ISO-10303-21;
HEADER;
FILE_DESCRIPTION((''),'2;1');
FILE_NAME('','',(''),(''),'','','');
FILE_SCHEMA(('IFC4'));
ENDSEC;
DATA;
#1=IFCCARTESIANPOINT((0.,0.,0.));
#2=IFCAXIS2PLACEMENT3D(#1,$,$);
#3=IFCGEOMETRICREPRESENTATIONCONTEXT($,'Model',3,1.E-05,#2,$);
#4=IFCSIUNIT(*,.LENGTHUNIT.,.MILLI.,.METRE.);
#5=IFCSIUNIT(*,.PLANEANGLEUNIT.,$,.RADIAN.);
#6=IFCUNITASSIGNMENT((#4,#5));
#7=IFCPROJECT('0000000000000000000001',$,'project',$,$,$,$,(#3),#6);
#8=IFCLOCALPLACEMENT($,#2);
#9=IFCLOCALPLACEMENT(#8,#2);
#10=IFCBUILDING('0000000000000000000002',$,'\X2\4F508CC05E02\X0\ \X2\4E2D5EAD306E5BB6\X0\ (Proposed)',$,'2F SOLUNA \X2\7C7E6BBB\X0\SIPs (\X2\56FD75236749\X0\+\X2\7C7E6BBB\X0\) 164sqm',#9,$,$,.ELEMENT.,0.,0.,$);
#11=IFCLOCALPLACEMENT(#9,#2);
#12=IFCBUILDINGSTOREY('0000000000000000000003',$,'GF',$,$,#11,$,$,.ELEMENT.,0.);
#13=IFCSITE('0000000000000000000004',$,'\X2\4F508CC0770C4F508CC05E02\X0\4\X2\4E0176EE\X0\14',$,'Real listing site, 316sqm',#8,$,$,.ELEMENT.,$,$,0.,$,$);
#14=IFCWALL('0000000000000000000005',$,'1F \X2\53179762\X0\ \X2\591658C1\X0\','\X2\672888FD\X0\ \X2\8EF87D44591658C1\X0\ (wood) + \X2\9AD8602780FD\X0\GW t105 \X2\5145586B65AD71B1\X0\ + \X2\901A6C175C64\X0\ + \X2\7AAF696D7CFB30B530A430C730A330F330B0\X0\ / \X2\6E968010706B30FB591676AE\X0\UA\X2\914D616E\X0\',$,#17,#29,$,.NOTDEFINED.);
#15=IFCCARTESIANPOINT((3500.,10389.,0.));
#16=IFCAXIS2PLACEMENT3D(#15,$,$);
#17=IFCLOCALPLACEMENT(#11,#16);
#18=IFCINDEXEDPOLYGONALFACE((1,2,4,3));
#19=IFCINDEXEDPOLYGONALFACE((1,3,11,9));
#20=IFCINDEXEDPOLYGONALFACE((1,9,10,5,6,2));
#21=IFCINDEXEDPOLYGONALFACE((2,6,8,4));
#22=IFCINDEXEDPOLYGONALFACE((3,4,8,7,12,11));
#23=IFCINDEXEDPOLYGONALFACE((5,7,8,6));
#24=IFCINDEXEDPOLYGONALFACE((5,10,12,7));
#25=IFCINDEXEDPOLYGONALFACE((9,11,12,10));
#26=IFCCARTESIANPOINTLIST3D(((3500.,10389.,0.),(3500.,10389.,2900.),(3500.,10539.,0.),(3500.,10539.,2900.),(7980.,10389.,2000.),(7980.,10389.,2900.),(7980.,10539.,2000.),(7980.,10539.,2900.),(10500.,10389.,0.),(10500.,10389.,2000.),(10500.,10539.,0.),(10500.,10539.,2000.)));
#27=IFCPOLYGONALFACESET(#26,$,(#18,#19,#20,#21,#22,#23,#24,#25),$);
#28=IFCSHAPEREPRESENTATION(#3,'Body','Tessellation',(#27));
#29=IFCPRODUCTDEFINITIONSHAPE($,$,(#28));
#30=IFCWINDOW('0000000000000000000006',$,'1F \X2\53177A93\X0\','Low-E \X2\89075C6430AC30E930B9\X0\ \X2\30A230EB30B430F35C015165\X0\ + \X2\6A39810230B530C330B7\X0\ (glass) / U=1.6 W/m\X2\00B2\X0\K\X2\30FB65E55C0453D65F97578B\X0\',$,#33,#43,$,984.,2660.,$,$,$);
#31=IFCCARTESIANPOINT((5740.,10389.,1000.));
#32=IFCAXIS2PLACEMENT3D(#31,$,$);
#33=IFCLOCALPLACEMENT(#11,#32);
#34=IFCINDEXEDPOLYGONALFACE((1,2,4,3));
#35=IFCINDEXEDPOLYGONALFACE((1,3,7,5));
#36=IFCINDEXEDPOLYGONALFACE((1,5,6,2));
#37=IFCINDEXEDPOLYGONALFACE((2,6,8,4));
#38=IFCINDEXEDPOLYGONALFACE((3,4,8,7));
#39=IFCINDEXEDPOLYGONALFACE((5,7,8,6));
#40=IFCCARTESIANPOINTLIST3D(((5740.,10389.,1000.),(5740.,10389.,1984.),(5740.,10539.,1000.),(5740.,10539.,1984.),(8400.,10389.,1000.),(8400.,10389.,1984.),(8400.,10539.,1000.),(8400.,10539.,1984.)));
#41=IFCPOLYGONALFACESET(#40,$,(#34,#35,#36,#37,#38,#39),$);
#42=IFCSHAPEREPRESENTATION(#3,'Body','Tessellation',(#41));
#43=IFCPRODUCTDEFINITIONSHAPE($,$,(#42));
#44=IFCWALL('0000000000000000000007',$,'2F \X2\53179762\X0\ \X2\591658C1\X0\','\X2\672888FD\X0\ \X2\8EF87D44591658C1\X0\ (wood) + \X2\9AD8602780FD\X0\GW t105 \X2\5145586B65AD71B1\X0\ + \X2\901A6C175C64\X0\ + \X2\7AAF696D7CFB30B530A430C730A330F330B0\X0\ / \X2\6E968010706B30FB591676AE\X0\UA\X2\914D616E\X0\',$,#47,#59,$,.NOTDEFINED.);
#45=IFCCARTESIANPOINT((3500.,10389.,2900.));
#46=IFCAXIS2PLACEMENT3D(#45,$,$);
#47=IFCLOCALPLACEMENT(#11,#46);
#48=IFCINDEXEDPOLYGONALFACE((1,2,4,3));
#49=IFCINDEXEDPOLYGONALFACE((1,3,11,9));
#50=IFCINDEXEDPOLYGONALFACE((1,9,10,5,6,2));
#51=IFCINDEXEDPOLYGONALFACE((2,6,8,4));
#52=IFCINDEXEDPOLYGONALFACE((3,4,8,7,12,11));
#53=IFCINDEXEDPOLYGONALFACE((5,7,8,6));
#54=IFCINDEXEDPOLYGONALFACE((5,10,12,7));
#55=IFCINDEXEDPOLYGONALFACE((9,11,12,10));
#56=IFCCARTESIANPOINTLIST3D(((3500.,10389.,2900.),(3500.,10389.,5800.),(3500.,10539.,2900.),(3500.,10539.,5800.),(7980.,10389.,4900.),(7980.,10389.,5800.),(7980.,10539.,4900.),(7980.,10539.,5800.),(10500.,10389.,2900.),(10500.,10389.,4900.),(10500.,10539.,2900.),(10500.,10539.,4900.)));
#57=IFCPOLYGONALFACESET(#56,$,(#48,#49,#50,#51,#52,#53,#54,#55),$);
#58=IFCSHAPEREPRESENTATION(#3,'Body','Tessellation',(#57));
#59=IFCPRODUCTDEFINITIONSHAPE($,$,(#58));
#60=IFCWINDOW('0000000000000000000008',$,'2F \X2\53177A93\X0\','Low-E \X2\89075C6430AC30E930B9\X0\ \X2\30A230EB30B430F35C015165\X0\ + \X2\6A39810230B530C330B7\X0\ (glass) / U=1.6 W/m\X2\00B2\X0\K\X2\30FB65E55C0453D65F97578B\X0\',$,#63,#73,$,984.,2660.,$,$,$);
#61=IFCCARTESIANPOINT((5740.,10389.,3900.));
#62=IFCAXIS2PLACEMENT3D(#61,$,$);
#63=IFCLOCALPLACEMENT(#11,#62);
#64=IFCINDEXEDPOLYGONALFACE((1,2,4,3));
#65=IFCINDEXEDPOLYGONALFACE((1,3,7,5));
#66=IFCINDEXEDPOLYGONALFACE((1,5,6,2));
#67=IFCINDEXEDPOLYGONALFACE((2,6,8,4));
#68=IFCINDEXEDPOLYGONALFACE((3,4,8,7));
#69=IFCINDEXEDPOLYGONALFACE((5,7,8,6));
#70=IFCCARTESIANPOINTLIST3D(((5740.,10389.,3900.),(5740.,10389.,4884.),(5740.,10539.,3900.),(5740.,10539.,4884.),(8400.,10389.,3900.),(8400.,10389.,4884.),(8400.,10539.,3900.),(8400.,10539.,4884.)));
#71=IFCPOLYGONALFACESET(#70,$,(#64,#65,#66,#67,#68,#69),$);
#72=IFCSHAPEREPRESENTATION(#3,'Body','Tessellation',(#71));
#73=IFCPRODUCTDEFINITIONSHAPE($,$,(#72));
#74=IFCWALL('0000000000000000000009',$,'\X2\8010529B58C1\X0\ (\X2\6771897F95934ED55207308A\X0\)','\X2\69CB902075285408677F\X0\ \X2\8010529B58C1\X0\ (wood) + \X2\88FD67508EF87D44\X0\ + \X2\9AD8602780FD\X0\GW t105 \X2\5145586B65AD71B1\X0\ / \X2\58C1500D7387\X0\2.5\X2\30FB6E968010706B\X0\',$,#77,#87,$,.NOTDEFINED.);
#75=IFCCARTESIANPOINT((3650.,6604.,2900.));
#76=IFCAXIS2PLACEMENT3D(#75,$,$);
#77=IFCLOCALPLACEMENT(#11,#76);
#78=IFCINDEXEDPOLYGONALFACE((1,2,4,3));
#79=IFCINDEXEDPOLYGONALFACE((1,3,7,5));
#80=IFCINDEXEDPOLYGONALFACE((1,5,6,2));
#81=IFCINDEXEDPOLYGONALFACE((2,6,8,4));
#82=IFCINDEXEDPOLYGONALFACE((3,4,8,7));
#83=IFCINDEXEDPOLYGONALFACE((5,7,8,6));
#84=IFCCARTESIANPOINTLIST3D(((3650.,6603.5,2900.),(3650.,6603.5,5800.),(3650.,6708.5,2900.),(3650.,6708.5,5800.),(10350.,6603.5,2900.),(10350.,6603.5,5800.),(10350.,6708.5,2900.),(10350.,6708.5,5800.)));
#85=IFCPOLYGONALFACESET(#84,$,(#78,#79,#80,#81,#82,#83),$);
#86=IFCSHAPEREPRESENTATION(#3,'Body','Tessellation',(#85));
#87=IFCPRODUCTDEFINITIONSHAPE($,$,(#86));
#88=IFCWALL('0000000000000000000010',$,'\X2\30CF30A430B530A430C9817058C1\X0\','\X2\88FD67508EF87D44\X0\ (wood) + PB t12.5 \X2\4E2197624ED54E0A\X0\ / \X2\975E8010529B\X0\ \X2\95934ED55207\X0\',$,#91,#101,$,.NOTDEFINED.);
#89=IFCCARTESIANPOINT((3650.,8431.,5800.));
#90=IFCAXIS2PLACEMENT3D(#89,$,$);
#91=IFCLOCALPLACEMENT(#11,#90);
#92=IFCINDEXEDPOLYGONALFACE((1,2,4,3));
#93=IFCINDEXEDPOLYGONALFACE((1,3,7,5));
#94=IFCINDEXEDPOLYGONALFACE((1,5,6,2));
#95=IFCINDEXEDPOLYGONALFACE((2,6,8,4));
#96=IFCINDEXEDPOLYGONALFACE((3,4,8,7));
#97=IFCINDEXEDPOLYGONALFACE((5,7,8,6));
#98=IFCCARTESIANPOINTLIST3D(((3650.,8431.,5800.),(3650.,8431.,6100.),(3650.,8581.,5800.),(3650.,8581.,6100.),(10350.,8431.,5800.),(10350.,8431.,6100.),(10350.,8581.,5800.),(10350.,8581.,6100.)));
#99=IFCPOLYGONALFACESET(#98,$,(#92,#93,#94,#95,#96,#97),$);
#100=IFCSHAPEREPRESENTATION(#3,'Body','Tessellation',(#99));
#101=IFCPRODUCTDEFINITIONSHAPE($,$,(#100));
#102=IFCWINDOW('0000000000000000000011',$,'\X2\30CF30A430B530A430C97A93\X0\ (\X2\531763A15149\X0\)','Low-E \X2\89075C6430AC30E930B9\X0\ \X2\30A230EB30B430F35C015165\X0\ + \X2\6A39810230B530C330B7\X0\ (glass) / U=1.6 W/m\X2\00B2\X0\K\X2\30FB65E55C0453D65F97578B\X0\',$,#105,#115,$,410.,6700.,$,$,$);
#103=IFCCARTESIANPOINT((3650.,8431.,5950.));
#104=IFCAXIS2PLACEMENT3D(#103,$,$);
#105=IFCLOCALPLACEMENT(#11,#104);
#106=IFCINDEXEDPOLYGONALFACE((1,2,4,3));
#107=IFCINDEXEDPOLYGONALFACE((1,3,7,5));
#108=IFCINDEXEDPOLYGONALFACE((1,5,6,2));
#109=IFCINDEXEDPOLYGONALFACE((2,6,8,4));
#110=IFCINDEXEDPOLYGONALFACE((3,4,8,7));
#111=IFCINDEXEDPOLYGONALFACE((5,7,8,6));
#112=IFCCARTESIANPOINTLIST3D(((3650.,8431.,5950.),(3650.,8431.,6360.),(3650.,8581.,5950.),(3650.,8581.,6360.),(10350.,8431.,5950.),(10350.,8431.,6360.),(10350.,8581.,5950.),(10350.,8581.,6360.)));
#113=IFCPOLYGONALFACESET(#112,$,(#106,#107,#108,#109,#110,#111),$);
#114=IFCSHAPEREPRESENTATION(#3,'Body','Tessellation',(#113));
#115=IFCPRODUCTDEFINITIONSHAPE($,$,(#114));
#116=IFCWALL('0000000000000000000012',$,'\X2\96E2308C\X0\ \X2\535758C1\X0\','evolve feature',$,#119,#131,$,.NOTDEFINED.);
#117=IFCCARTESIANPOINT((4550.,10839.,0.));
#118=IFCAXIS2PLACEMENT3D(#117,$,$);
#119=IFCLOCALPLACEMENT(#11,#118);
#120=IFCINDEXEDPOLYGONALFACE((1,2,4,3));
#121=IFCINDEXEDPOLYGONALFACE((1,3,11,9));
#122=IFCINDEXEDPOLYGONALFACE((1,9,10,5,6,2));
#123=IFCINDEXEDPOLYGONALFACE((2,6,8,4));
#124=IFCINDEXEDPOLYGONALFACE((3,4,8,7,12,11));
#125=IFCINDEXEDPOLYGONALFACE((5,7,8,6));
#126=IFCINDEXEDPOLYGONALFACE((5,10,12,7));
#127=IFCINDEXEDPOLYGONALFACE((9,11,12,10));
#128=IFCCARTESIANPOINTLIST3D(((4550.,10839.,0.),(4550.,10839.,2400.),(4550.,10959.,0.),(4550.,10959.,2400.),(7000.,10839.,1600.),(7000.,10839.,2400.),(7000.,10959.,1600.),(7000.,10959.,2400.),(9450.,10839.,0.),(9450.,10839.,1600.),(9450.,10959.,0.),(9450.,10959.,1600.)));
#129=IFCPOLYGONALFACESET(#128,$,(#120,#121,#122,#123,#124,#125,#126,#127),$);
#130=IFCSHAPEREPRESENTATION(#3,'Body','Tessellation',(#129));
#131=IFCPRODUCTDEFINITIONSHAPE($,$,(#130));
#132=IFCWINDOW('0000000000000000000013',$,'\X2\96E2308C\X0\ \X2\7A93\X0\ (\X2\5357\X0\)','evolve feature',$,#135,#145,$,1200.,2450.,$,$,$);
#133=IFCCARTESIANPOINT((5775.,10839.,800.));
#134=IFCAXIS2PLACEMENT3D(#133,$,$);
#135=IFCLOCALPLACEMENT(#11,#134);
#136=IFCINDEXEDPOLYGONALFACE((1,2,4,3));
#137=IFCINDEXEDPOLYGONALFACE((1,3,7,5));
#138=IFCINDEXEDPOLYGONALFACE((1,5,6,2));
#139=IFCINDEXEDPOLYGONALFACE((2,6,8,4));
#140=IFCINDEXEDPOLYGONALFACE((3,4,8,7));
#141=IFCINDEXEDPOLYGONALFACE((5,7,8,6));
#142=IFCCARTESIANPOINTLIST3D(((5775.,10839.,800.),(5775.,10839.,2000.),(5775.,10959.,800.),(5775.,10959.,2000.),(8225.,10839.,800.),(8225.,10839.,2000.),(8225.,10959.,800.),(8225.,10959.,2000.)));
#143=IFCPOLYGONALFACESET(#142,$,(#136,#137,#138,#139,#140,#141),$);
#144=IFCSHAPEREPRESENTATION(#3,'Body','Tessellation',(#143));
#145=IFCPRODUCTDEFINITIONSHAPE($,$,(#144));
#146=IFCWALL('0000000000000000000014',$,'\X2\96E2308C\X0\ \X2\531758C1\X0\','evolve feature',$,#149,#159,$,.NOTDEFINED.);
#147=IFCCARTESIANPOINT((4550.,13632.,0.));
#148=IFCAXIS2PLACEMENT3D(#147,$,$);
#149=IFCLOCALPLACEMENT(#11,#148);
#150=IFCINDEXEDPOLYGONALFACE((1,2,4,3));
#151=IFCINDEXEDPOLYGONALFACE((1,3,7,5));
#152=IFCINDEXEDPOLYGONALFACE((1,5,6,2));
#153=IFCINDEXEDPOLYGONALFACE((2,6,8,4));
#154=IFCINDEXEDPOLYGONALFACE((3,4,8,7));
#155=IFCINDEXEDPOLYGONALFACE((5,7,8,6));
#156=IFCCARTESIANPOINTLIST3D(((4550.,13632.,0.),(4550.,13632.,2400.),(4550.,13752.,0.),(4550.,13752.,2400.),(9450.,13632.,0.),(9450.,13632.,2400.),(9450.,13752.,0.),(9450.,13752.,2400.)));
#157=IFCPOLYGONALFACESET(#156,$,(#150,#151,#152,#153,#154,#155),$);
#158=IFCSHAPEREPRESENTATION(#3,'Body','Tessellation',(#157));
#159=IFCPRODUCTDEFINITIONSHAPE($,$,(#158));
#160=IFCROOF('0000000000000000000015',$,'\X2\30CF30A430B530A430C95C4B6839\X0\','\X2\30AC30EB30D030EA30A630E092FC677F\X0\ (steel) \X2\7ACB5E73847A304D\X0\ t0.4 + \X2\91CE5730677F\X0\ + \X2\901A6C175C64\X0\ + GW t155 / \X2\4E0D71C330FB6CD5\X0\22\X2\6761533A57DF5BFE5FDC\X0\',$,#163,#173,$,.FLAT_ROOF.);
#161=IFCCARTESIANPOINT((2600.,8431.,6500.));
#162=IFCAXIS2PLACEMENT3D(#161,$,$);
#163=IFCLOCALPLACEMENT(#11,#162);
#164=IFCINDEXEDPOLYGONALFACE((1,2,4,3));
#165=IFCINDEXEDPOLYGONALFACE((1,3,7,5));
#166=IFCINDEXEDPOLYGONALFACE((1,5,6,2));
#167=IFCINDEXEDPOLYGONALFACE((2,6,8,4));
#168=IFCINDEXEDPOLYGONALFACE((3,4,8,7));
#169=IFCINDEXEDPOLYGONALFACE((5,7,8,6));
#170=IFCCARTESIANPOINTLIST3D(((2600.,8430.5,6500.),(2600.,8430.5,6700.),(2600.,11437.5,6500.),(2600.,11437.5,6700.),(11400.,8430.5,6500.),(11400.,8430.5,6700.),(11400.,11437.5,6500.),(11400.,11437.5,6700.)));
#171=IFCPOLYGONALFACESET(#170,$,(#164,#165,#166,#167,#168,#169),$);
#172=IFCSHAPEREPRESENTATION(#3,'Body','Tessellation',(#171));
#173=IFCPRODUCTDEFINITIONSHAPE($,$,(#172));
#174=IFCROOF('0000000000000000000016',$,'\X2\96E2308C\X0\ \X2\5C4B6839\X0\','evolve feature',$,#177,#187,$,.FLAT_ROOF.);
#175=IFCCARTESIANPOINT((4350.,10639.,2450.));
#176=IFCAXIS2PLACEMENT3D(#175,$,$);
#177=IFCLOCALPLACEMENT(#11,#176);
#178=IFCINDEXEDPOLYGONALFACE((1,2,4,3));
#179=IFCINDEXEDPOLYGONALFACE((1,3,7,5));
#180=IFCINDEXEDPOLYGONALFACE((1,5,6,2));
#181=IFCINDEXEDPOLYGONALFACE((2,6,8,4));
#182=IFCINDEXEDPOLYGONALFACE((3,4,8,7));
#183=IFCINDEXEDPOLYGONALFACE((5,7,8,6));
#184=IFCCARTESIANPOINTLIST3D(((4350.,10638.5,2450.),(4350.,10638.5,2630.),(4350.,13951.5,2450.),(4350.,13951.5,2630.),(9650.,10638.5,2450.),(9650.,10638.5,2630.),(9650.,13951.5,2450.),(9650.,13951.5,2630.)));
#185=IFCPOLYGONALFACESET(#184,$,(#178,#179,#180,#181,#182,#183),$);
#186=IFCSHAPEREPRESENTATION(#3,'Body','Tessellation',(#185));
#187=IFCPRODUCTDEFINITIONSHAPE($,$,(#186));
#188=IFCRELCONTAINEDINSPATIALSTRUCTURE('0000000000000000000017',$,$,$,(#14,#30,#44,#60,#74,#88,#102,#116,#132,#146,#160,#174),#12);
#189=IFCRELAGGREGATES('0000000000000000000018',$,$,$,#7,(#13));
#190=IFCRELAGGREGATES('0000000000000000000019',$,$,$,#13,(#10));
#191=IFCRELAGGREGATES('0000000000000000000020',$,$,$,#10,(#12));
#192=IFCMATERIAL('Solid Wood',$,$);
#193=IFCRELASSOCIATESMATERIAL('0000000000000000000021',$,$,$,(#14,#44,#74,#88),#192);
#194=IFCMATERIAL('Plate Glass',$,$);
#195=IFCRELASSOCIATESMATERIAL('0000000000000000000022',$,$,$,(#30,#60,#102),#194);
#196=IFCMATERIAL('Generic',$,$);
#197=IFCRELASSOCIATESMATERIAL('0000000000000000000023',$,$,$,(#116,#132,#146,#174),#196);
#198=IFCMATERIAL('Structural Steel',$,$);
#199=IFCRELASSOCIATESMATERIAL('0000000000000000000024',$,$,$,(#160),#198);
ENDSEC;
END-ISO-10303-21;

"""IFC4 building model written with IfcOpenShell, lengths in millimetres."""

from ifc_helpers import new_model, si_unit, frame, frame_2d, origin, place, context, project, spatial, rectangle, extrude, material, element, fill, save


model = new_model("IFC4")

# Units and contexts
model_context = context("Model", 3, precision=1e-05, world=origin())
ifc_project = project(units=[si_unit("LENGTHUNIT", "METRE", prefix="MILLI"), si_unit("PLANEANGLEUNIT", "RADIAN")], contexts=[model_context])

# Site, building, storey
site_placement = place(None, origin())
site = spatial("IfcSite", under=ifc_project, at=site_placement, Name="佐賀県佐賀市4丁目14", ObjectType="Real listing site, 316sqm", CompositionType="ELEMENT", RefElevation=0.0)
building_placement = place(site_placement, origin())
building = spatial("IfcBuilding", under=site, at=building_placement, Name="佐賀市 中庭の家 (Proposed)", ObjectType="2F SOLUNA 籾殻SIPs (国産杉+籾殻) 164sqm", CompositionType="ELEMENT", ElevationOfRefHeight=0.0, ElevationOfTerrain=0.0)
storey_placement = place(building_placement, origin())
storey = spatial("IfcBuildingStorey", under=building, at=storey_placement, Name="GF", CompositionType="ELEMENT", Elevation=0.0)

# Shared definitions
ifc_material_1 = material(Name="Generic")

# Wall, opening, window
ifc_material_2 = material(Name="Solid Wood")
wall_1_placement = place(storey_placement, frame((3500.0, 10389.0, 0.0)))
wall_1 = element("IfcWall", 1, at=wall_1_placement, inside=storey, material=ifc_material_2, Name="1F 北面 外壁", Description="木製 軸組外壁 (wood) + 高性能GW t105 充填断熱 + 通気層 + 窯業系サイディング / 準耐火・外皮UA配慮", PredefinedType="NOTDEFINED", context=model_context, shape_type="SweptSolid", body=[
    extrude(rectangle(XDim=7000.0, YDim=150.0, at=frame_2d((3500.0, 75.0))), frame((3500.0, 10389.0, 0.0)), (0.0, 0.0, 1.0), 2900.0),
])
opening_1_placement = place(storey_placement, frame((5740.0, 10389.0, 1000.0)))
opening_1 = element("IfcOpeningElement", 2, at=opening_1_placement, cuts=wall_1, PredefinedType="NOTDEFINED", context=model_context, shape_type="SweptSolid", body=[
    extrude(rectangle(XDim=2660.0, YDim=150.0, at=frame_2d((1330.0, 75.0))), frame((5740.0, 10389.0, 1000.0)), (0.0, 0.0, 1.0), 984.0),
])
ifc_material_3 = material(Name="Plate Glass")
window_1_placement = place(storey_placement, frame((5740.0, 10389.0, 1000.0)))
window_1 = element("IfcWindow", 3, at=window_1_placement, inside=storey, material=ifc_material_3, Name="1F 北窓", Description="Low-E 複層ガラス アルゴン封入 + 樹脂サッシ (glass) / U=1.6 W/m²K・日射取得型", OverallHeight=984.0, OverallWidth=2660.0, context=model_context, shape_type="SweptSolid", body=[
    extrude(rectangle(XDim=2660.0, YDim=150.0, at=frame_2d((1330.0, 75.0))), frame((5740.0, 10389.0, 1000.0)), (0.0, 0.0, 1.0), 984.0),
])
fill(opening_1, window_1)

# Wall, opening, window
wall_2_placement = place(storey_placement, frame((3500.0, 10389.0, 2900.0)))
wall_2 = element("IfcWall", 4, at=wall_2_placement, inside=storey, material=ifc_material_2, Name="2F 北面 外壁", Description="木製 軸組外壁 (wood) + 高性能GW t105 充填断熱 + 通気層 + 窯業系サイディング / 準耐火・外皮UA配慮", PredefinedType="NOTDEFINED", context=model_context, shape_type="SweptSolid", body=[
    extrude(rectangle(XDim=7000.0, YDim=150.0, at=frame_2d((3500.0, 75.0))), frame((3500.0, 10389.0, 2900.0)), (0.0, 0.0, 1.0), 2900.0),
])
opening_2_placement = place(storey_placement, frame((5740.0, 10389.0, 3900.0)))
opening_2 = element("IfcOpeningElement", 5, at=opening_2_placement, cuts=wall_2, PredefinedType="NOTDEFINED", context=model_context, shape_type="SweptSolid", body=[
    extrude(rectangle(XDim=2660.0, YDim=150.0, at=frame_2d((1330.0, 75.0))), frame((5740.0, 10389.0, 3900.0)), (0.0, 0.0, 1.0), 984.0),
])
window_2_placement = place(storey_placement, frame((5740.0, 10389.0, 3900.0)))
window_2 = element("IfcWindow", 6, at=window_2_placement, inside=storey, material=ifc_material_3, Name="2F 北窓", Description="Low-E 複層ガラス アルゴン封入 + 樹脂サッシ (glass) / U=1.6 W/m²K・日射取得型", OverallHeight=984.0, OverallWidth=2660.0, context=model_context, shape_type="SweptSolid", body=[
    extrude(rectangle(XDim=2660.0, YDim=150.0, at=frame_2d((1330.0, 75.0))), frame((5740.0, 10389.0, 3900.0)), (0.0, 0.0, 1.0), 984.0),
])
fill(opening_2, window_2)

# Wall
wall_3_placement = place(storey_placement, frame((3650.0, 6604.0, 2900.0)))
element("IfcWall", 7, at=wall_3_placement, inside=storey, material=ifc_material_2, Name="耐力壁 (東西間仕切り)", Description="構造用合板 耐力壁 (wood) + 製材軸組 + 高性能GW t105 充填断熱 / 壁倍率2.5・準耐火", PredefinedType="NOTDEFINED", context=model_context, shape_type="SweptSolid", body=[
    extrude(rectangle(XDim=6700.0, YDim=105.0, at=frame_2d((3350.0, 52.0))), frame((3650.0, 6604.0, 2900.0)), (0.0, 0.0, 1.0), 2900.0),
])

# Walls, openings, windows
wall_4_placement = place(storey_placement, frame((3650.0, 8431.0, 5800.0)))
wall_4 = element("IfcWall", 8, at=wall_4_placement, inside=storey, material=ifc_material_2, Name="ハイサイド腰壁", Description="製材軸組 (wood) + PB t12.5 両面仕上 / 非耐力 間仕切", PredefinedType="NOTDEFINED", context=model_context, shape_type="SweptSolid", body=[
    extrude(rectangle(XDim=6700.0, YDim=150.0, at=frame_2d((3350.0, 75.0))), frame((3650.0, 8431.0, 5800.0)), (0.0, 0.0, 1.0), 700.0),
])
opening_3_placement = place(storey_placement, frame((3650.0, 8431.0, 5950.0)))
opening_3 = element("IfcOpeningElement", 9, at=opening_3_placement, cuts=wall_4, PredefinedType="NOTDEFINED", context=model_context, shape_type="SweptSolid", body=[
    extrude(rectangle(XDim=6700.0, YDim=150.0, at=frame_2d((3350.0, 75.0))), frame((3650.0, 8431.0, 5950.0)), (0.0, 0.0, 1.0), 410.0),
])
window_3_placement = place(storey_placement, frame((3650.0, 8431.0, 5950.0)))
window_3 = element("IfcWindow", 10, at=window_3_placement, inside=storey, material=ifc_material_3, Name="ハイサイド窓 (北採光)", Description="Low-E 複層ガラス アルゴン封入 + 樹脂サッシ (glass) / U=1.6 W/m²K・日射取得型", OverallHeight=410.0, OverallWidth=6700.0, context=model_context, shape_type="SweptSolid", body=[
    extrude(rectangle(XDim=6700.0, YDim=150.0, at=frame_2d((3350.0, 75.0))), frame((3650.0, 8431.0, 5950.0)), (0.0, 0.0, 1.0), 410.0),
])
fill(opening_3, window_3)
wall_5_placement = place(storey_placement, frame((4550.0, 10839.0, 0.0)))
wall_5 = element("IfcWall", 11, at=wall_5_placement, inside=storey, material=ifc_material_1, Name="離れ 南壁", Description="evolve feature", PredefinedType="NOTDEFINED", context=model_context, shape_type="SweptSolid", body=[
    extrude(rectangle(XDim=4900.0, YDim=120.0, at=frame_2d((2450.0, 60.0))), frame((4550.0, 10839.0, 0.0)), (0.0, 0.0, 1.0), 2400.0),
])
opening_4_placement = place(storey_placement, frame((5775.0, 10839.0, 800.0)))
opening_4 = element("IfcOpeningElement", 12, at=opening_4_placement, cuts=wall_5, PredefinedType="NOTDEFINED", context=model_context, shape_type="SweptSolid", body=[
    extrude(rectangle(XDim=2450.0, YDim=120.0, at=frame_2d((1225.0, 60.0))), frame((5775.0, 10839.0, 800.0)), (0.0, 0.0, 1.0), 1200.0),
])
window_4_placement = place(storey_placement, frame((5775.0, 10839.0, 800.0)))
window_4 = element("IfcWindow", 13, at=window_4_placement, inside=storey, material=ifc_material_1, Name="離れ 窓 (南)", Description="evolve feature", OverallHeight=1200.0, OverallWidth=2450.0, context=model_context, shape_type="SweptSolid", body=[
    extrude(rectangle(XDim=2450.0, YDim=120.0, at=frame_2d((1225.0, 60.0))), frame((5775.0, 10839.0, 800.0)), (0.0, 0.0, 1.0), 1200.0),
])
fill(opening_4, window_4)

# Wall
wall_6_placement = place(storey_placement, frame((4550.0, 13632.0, 0.0)))
element("IfcWall", 14, at=wall_6_placement, inside=storey, material=ifc_material_1, Name="離れ 北壁", Description="evolve feature", PredefinedType="NOTDEFINED", context=model_context, shape_type="SweptSolid", body=[
    extrude(rectangle(XDim=4900.0, YDim=120.0, at=frame_2d((2450.0, 60.0))), frame((4550.0, 13632.0, 0.0)), (0.0, 0.0, 1.0), 2400.0),
])

# Roofs
ifc_material_4 = material(Name="Structural Steel")
roof_1_placement = place(storey_placement, frame((2600.0, 8431.0, 6500.0)))
element("IfcRoof", 15, at=roof_1_placement, inside=storey, material=ifc_material_4, Name="ハイサイド屋根", Description="ガルバリウム鋼板 (steel) 立平葺き t0.4 + 野地板 + 通気層 + GW t155 / 不燃・法22条区域対応", PredefinedType="FLAT_ROOF", context=model_context, shape_type="SweptSolid", body=[
    extrude(rectangle(XDim=8800.0, YDim=3007.0, at=frame_2d((4400.0, 1503.0))), frame((2600.0, 8431.0, 6500.0)), (0.0, 0.0, 1.0), 200.0),
])
roof_2_placement = place(storey_placement, frame((4350.0, 10639.0, 2450.0)))
element("IfcRoof", 16, at=roof_2_placement, inside=storey, material=ifc_material_1, Name="離れ 屋根", Description="evolve feature", PredefinedType="FLAT_ROOF", context=model_context, shape_type="SweptSolid", body=[
    extrude(rectangle(XDim=5300.0, YDim=3313.0, at=frame_2d((2650.0, 1656.0))), frame((4350.0, 10639.0, 2450.0)), (0.0, 0.0, 1.0), 180.0),
])

save(model, "model.ifc")
